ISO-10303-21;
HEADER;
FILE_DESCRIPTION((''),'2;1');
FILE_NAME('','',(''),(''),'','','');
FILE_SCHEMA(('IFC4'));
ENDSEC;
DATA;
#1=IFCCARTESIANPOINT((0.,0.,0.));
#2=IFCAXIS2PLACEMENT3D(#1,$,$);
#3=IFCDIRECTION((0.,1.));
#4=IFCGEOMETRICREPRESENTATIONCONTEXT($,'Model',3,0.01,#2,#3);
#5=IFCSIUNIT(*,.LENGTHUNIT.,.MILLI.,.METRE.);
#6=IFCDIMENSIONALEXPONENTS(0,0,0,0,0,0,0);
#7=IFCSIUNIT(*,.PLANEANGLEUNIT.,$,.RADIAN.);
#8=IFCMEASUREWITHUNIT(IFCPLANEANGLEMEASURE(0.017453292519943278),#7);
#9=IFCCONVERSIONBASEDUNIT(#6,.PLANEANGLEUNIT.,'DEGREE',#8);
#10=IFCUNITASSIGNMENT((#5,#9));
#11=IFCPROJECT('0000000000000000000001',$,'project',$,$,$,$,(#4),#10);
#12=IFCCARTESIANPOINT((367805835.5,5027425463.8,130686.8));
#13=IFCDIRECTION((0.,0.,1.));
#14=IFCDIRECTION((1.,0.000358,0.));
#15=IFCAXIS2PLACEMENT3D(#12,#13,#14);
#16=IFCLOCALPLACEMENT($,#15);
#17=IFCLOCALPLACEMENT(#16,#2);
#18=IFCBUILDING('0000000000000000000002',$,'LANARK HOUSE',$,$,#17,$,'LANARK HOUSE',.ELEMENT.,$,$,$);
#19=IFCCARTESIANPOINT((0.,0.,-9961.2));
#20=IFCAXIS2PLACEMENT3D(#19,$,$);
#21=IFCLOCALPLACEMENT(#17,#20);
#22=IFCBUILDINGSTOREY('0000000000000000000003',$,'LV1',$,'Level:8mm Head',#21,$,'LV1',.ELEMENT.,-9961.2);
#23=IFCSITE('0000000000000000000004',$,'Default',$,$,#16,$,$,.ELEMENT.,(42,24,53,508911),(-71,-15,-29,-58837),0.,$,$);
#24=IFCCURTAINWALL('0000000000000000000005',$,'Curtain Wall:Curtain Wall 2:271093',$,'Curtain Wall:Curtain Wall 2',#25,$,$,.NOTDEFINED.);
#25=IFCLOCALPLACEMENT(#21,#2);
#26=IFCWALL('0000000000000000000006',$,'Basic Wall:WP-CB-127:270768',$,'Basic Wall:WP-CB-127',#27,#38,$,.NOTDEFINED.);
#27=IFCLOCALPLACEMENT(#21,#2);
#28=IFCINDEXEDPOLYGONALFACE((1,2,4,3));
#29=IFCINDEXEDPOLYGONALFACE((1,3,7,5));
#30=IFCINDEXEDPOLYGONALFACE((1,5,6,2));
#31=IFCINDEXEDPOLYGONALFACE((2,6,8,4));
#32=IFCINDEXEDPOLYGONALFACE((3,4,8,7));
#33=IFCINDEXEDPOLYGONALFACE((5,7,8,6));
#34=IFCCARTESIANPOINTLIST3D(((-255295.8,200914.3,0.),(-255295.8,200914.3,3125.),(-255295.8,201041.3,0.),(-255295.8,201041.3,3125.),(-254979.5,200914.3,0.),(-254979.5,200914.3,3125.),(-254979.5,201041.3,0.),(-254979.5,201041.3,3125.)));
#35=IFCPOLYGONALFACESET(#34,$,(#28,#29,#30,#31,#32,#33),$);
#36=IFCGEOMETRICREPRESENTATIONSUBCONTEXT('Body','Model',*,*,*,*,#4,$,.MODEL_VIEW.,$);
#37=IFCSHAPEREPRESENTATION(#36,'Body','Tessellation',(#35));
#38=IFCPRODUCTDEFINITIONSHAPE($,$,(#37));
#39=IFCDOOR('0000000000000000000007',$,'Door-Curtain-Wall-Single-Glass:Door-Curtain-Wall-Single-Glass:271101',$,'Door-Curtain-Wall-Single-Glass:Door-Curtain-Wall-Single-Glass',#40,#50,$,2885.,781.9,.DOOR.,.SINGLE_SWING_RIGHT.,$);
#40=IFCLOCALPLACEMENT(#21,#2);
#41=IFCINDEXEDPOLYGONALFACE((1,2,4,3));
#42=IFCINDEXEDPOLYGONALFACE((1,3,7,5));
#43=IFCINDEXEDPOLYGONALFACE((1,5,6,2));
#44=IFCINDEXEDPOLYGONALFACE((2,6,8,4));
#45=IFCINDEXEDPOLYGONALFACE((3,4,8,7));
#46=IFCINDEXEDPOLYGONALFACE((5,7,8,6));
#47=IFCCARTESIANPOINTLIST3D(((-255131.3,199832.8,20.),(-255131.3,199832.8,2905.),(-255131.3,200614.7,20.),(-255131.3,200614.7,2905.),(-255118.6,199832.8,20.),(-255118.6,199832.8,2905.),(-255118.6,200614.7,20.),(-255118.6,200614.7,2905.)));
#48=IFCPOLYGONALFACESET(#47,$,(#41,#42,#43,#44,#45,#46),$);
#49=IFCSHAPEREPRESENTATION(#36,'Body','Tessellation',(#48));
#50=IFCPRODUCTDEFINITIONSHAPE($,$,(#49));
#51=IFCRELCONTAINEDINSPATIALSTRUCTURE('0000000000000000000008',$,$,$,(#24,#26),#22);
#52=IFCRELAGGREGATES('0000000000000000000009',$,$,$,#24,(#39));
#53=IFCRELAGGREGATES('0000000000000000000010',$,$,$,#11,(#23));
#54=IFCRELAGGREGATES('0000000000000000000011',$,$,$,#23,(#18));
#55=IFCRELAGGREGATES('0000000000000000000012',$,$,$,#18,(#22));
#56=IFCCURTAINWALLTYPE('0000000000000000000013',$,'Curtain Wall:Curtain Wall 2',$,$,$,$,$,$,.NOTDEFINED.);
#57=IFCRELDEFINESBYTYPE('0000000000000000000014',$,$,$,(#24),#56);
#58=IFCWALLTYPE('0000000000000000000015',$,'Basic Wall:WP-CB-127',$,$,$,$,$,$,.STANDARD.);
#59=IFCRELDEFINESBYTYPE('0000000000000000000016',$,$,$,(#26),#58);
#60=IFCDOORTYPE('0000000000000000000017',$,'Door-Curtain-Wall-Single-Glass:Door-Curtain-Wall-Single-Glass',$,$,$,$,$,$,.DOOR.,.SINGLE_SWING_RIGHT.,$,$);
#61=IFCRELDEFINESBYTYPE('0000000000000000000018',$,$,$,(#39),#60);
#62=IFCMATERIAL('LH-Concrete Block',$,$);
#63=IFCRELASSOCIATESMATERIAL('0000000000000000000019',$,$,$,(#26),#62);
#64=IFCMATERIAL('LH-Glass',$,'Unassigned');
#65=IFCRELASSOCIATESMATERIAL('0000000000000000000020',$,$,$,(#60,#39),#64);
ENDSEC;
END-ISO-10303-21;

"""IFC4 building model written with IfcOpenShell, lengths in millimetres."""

from ifc_helpers import new_model, entity, si_unit, converted_unit, direction, frame, origin, place, context, subcontext, project, spatial, indexed_curve, outline, extrude, source, transform, mapped, material, type_object, type_shapes, element, aggregate, save


model = new_model("IFC4")

# Units and contexts
model_context = context("Model", 3, precision=0.01, world=origin(), true_north=direction((0.0, 1.0)))
body_context = subcontext(model_context, "Body", "Model", "MODEL_VIEW")
ifc_project = project(units=[si_unit("LENGTHUNIT", "METRE", prefix="MILLI"), converted_unit("PLANEANGLEUNIT", "DEGREE", entity("IfcPlaneAngleMeasure", 0.017453292519943278), si_unit("PLANEANGLEUNIT", "RADIAN"), dimensions=[0, 0, 0, 0, 0, 0, 0])], contexts=[model_context])

# Site, building, storey
site_placement = place(None, frame((367805835.5, 5027425463.8, 130686.8), z_axis=(0.0, 0.0, 1.0), x_axis=(1.0, 0.000358, 0.0)))
site = spatial("IfcSite", under=ifc_project, at=site_placement, Name="Default", CompositionType="ELEMENT", RefLatitude=(42, 24, 53, 508911), RefLongitude=(-71, -15, -29, -58837), RefElevation=0.0)
building_placement = place(site_placement, origin())
building = spatial("IfcBuilding", under=site, at=building_placement, Name="LANARK HOUSE", LongName="LANARK HOUSE", CompositionType="ELEMENT")
storey_placement = place(building_placement, frame((0.0, 0.0, -9961.2)))
storey = spatial("IfcBuildingStorey", under=building, at=storey_placement, Name="LV1", ObjectType="Level:8mm Head", LongName="LV1", CompositionType="ELEMENT", Elevation=-9961.2)

# Curtain wall
curtain_wall_type = type_object("IfcCurtainWallType", Name="Curtain Wall:Curtain Wall 2", PredefinedType="NOTDEFINED")
curtain_wall_placement = place(storey_placement, frame((0.0, 0.0, 9961.2)))
curtain_wall = element("IfcCurtainWall", 1, at=curtain_wall_placement, inside=storey, type_object=curtain_wall_type, Name="Curtain Wall:Curtain Wall 2:271093", ObjectType="Curtain Wall:Curtain Wall 2", PredefinedType="NOTDEFINED")

# Shared definitions
ifc_material_1 = material(Name="LH-Glass", Category="Unassigned")

# Shared definitions
ifc_material_2 = material(Name="LH-Concrete Block")

# Wall
wall_type_1 = type_object("IfcWallType", Name="Basic Wall:WP-CB-127", PredefinedType="STANDARD")
wall_1_placement = place(storey_placement, frame((-255295.8, 200977.8, 0.0)))
element("IfcWall", 2, at=wall_1_placement, inside=storey, type_object=wall_type_1, material=ifc_material_2, Name="Basic Wall:WP-CB-127:270768", ObjectType="Basic Wall:WP-CB-127", PredefinedType="NOTDEFINED", context=body_context, shape_type="SweptSolid", body=[
    extrude(outline(indexed_curve([(316.2, 63.5), (0.0, 63.5), (0.0, -63.5), (316.2, -63.5), (316.2, 63.5)], self_intersect=False)), origin(), (0.0, 0.0, 1.0), 3125.0),
])

# Door
door_type_1 = type_object("IfcDoorType", Name="Door-Curtain-Wall-Single-Glass:Door-Curtain-Wall-Single-Glass", OperationType="SINGLE_SWING_RIGHT", PredefinedType="DOOR", material=ifc_material_1)
shared_shape_1 = source(origin(), body_context, "Body", "SweptSolid", [
    extrude(outline(indexed_curve([(-390.9, -6.4), (390.9, -6.4), (390.9, 6.4), (-390.9, 6.4), (-390.9, -6.4)], self_intersect=False)), frame((0.0, 44.5, 0.0), z_axis=(0.0, 0.0, 1.0), x_axis=(-1.0, 0.0, 0.0)), (0.0, 0.0, 1.0), 2885.0),
])
type_shapes(door_type_1, [shared_shape_1])
door_1_placement = place(curtain_wall_placement, frame((-255080.5, 200223.8, -9941.2), z_axis=(0.0, 0.0, 1.0), x_axis=(0.0, 1.0, 0.0)))
door_1 = element("IfcDoor", 3, at=door_1_placement, type_object=door_type_1, material=ifc_material_1, Name="Door-Curtain-Wall-Single-Glass:Door-Curtain-Wall-Single-Glass:271101", ObjectType="Door-Curtain-Wall-Single-Glass:Door-Curtain-Wall-Single-Glass", OperationType="SINGLE_SWING_RIGHT", OverallHeight=2885.0, OverallWidth=781.9, PredefinedType="DOOR", context=body_context, shape_type="MappedRepresentation", body=[
    mapped(shared_shape_1, transform((0.0, 0.0, 0.0), scale=1.0)),
])
aggregate(curtain_wall, [door_1])

save(model, "model.ifc")
